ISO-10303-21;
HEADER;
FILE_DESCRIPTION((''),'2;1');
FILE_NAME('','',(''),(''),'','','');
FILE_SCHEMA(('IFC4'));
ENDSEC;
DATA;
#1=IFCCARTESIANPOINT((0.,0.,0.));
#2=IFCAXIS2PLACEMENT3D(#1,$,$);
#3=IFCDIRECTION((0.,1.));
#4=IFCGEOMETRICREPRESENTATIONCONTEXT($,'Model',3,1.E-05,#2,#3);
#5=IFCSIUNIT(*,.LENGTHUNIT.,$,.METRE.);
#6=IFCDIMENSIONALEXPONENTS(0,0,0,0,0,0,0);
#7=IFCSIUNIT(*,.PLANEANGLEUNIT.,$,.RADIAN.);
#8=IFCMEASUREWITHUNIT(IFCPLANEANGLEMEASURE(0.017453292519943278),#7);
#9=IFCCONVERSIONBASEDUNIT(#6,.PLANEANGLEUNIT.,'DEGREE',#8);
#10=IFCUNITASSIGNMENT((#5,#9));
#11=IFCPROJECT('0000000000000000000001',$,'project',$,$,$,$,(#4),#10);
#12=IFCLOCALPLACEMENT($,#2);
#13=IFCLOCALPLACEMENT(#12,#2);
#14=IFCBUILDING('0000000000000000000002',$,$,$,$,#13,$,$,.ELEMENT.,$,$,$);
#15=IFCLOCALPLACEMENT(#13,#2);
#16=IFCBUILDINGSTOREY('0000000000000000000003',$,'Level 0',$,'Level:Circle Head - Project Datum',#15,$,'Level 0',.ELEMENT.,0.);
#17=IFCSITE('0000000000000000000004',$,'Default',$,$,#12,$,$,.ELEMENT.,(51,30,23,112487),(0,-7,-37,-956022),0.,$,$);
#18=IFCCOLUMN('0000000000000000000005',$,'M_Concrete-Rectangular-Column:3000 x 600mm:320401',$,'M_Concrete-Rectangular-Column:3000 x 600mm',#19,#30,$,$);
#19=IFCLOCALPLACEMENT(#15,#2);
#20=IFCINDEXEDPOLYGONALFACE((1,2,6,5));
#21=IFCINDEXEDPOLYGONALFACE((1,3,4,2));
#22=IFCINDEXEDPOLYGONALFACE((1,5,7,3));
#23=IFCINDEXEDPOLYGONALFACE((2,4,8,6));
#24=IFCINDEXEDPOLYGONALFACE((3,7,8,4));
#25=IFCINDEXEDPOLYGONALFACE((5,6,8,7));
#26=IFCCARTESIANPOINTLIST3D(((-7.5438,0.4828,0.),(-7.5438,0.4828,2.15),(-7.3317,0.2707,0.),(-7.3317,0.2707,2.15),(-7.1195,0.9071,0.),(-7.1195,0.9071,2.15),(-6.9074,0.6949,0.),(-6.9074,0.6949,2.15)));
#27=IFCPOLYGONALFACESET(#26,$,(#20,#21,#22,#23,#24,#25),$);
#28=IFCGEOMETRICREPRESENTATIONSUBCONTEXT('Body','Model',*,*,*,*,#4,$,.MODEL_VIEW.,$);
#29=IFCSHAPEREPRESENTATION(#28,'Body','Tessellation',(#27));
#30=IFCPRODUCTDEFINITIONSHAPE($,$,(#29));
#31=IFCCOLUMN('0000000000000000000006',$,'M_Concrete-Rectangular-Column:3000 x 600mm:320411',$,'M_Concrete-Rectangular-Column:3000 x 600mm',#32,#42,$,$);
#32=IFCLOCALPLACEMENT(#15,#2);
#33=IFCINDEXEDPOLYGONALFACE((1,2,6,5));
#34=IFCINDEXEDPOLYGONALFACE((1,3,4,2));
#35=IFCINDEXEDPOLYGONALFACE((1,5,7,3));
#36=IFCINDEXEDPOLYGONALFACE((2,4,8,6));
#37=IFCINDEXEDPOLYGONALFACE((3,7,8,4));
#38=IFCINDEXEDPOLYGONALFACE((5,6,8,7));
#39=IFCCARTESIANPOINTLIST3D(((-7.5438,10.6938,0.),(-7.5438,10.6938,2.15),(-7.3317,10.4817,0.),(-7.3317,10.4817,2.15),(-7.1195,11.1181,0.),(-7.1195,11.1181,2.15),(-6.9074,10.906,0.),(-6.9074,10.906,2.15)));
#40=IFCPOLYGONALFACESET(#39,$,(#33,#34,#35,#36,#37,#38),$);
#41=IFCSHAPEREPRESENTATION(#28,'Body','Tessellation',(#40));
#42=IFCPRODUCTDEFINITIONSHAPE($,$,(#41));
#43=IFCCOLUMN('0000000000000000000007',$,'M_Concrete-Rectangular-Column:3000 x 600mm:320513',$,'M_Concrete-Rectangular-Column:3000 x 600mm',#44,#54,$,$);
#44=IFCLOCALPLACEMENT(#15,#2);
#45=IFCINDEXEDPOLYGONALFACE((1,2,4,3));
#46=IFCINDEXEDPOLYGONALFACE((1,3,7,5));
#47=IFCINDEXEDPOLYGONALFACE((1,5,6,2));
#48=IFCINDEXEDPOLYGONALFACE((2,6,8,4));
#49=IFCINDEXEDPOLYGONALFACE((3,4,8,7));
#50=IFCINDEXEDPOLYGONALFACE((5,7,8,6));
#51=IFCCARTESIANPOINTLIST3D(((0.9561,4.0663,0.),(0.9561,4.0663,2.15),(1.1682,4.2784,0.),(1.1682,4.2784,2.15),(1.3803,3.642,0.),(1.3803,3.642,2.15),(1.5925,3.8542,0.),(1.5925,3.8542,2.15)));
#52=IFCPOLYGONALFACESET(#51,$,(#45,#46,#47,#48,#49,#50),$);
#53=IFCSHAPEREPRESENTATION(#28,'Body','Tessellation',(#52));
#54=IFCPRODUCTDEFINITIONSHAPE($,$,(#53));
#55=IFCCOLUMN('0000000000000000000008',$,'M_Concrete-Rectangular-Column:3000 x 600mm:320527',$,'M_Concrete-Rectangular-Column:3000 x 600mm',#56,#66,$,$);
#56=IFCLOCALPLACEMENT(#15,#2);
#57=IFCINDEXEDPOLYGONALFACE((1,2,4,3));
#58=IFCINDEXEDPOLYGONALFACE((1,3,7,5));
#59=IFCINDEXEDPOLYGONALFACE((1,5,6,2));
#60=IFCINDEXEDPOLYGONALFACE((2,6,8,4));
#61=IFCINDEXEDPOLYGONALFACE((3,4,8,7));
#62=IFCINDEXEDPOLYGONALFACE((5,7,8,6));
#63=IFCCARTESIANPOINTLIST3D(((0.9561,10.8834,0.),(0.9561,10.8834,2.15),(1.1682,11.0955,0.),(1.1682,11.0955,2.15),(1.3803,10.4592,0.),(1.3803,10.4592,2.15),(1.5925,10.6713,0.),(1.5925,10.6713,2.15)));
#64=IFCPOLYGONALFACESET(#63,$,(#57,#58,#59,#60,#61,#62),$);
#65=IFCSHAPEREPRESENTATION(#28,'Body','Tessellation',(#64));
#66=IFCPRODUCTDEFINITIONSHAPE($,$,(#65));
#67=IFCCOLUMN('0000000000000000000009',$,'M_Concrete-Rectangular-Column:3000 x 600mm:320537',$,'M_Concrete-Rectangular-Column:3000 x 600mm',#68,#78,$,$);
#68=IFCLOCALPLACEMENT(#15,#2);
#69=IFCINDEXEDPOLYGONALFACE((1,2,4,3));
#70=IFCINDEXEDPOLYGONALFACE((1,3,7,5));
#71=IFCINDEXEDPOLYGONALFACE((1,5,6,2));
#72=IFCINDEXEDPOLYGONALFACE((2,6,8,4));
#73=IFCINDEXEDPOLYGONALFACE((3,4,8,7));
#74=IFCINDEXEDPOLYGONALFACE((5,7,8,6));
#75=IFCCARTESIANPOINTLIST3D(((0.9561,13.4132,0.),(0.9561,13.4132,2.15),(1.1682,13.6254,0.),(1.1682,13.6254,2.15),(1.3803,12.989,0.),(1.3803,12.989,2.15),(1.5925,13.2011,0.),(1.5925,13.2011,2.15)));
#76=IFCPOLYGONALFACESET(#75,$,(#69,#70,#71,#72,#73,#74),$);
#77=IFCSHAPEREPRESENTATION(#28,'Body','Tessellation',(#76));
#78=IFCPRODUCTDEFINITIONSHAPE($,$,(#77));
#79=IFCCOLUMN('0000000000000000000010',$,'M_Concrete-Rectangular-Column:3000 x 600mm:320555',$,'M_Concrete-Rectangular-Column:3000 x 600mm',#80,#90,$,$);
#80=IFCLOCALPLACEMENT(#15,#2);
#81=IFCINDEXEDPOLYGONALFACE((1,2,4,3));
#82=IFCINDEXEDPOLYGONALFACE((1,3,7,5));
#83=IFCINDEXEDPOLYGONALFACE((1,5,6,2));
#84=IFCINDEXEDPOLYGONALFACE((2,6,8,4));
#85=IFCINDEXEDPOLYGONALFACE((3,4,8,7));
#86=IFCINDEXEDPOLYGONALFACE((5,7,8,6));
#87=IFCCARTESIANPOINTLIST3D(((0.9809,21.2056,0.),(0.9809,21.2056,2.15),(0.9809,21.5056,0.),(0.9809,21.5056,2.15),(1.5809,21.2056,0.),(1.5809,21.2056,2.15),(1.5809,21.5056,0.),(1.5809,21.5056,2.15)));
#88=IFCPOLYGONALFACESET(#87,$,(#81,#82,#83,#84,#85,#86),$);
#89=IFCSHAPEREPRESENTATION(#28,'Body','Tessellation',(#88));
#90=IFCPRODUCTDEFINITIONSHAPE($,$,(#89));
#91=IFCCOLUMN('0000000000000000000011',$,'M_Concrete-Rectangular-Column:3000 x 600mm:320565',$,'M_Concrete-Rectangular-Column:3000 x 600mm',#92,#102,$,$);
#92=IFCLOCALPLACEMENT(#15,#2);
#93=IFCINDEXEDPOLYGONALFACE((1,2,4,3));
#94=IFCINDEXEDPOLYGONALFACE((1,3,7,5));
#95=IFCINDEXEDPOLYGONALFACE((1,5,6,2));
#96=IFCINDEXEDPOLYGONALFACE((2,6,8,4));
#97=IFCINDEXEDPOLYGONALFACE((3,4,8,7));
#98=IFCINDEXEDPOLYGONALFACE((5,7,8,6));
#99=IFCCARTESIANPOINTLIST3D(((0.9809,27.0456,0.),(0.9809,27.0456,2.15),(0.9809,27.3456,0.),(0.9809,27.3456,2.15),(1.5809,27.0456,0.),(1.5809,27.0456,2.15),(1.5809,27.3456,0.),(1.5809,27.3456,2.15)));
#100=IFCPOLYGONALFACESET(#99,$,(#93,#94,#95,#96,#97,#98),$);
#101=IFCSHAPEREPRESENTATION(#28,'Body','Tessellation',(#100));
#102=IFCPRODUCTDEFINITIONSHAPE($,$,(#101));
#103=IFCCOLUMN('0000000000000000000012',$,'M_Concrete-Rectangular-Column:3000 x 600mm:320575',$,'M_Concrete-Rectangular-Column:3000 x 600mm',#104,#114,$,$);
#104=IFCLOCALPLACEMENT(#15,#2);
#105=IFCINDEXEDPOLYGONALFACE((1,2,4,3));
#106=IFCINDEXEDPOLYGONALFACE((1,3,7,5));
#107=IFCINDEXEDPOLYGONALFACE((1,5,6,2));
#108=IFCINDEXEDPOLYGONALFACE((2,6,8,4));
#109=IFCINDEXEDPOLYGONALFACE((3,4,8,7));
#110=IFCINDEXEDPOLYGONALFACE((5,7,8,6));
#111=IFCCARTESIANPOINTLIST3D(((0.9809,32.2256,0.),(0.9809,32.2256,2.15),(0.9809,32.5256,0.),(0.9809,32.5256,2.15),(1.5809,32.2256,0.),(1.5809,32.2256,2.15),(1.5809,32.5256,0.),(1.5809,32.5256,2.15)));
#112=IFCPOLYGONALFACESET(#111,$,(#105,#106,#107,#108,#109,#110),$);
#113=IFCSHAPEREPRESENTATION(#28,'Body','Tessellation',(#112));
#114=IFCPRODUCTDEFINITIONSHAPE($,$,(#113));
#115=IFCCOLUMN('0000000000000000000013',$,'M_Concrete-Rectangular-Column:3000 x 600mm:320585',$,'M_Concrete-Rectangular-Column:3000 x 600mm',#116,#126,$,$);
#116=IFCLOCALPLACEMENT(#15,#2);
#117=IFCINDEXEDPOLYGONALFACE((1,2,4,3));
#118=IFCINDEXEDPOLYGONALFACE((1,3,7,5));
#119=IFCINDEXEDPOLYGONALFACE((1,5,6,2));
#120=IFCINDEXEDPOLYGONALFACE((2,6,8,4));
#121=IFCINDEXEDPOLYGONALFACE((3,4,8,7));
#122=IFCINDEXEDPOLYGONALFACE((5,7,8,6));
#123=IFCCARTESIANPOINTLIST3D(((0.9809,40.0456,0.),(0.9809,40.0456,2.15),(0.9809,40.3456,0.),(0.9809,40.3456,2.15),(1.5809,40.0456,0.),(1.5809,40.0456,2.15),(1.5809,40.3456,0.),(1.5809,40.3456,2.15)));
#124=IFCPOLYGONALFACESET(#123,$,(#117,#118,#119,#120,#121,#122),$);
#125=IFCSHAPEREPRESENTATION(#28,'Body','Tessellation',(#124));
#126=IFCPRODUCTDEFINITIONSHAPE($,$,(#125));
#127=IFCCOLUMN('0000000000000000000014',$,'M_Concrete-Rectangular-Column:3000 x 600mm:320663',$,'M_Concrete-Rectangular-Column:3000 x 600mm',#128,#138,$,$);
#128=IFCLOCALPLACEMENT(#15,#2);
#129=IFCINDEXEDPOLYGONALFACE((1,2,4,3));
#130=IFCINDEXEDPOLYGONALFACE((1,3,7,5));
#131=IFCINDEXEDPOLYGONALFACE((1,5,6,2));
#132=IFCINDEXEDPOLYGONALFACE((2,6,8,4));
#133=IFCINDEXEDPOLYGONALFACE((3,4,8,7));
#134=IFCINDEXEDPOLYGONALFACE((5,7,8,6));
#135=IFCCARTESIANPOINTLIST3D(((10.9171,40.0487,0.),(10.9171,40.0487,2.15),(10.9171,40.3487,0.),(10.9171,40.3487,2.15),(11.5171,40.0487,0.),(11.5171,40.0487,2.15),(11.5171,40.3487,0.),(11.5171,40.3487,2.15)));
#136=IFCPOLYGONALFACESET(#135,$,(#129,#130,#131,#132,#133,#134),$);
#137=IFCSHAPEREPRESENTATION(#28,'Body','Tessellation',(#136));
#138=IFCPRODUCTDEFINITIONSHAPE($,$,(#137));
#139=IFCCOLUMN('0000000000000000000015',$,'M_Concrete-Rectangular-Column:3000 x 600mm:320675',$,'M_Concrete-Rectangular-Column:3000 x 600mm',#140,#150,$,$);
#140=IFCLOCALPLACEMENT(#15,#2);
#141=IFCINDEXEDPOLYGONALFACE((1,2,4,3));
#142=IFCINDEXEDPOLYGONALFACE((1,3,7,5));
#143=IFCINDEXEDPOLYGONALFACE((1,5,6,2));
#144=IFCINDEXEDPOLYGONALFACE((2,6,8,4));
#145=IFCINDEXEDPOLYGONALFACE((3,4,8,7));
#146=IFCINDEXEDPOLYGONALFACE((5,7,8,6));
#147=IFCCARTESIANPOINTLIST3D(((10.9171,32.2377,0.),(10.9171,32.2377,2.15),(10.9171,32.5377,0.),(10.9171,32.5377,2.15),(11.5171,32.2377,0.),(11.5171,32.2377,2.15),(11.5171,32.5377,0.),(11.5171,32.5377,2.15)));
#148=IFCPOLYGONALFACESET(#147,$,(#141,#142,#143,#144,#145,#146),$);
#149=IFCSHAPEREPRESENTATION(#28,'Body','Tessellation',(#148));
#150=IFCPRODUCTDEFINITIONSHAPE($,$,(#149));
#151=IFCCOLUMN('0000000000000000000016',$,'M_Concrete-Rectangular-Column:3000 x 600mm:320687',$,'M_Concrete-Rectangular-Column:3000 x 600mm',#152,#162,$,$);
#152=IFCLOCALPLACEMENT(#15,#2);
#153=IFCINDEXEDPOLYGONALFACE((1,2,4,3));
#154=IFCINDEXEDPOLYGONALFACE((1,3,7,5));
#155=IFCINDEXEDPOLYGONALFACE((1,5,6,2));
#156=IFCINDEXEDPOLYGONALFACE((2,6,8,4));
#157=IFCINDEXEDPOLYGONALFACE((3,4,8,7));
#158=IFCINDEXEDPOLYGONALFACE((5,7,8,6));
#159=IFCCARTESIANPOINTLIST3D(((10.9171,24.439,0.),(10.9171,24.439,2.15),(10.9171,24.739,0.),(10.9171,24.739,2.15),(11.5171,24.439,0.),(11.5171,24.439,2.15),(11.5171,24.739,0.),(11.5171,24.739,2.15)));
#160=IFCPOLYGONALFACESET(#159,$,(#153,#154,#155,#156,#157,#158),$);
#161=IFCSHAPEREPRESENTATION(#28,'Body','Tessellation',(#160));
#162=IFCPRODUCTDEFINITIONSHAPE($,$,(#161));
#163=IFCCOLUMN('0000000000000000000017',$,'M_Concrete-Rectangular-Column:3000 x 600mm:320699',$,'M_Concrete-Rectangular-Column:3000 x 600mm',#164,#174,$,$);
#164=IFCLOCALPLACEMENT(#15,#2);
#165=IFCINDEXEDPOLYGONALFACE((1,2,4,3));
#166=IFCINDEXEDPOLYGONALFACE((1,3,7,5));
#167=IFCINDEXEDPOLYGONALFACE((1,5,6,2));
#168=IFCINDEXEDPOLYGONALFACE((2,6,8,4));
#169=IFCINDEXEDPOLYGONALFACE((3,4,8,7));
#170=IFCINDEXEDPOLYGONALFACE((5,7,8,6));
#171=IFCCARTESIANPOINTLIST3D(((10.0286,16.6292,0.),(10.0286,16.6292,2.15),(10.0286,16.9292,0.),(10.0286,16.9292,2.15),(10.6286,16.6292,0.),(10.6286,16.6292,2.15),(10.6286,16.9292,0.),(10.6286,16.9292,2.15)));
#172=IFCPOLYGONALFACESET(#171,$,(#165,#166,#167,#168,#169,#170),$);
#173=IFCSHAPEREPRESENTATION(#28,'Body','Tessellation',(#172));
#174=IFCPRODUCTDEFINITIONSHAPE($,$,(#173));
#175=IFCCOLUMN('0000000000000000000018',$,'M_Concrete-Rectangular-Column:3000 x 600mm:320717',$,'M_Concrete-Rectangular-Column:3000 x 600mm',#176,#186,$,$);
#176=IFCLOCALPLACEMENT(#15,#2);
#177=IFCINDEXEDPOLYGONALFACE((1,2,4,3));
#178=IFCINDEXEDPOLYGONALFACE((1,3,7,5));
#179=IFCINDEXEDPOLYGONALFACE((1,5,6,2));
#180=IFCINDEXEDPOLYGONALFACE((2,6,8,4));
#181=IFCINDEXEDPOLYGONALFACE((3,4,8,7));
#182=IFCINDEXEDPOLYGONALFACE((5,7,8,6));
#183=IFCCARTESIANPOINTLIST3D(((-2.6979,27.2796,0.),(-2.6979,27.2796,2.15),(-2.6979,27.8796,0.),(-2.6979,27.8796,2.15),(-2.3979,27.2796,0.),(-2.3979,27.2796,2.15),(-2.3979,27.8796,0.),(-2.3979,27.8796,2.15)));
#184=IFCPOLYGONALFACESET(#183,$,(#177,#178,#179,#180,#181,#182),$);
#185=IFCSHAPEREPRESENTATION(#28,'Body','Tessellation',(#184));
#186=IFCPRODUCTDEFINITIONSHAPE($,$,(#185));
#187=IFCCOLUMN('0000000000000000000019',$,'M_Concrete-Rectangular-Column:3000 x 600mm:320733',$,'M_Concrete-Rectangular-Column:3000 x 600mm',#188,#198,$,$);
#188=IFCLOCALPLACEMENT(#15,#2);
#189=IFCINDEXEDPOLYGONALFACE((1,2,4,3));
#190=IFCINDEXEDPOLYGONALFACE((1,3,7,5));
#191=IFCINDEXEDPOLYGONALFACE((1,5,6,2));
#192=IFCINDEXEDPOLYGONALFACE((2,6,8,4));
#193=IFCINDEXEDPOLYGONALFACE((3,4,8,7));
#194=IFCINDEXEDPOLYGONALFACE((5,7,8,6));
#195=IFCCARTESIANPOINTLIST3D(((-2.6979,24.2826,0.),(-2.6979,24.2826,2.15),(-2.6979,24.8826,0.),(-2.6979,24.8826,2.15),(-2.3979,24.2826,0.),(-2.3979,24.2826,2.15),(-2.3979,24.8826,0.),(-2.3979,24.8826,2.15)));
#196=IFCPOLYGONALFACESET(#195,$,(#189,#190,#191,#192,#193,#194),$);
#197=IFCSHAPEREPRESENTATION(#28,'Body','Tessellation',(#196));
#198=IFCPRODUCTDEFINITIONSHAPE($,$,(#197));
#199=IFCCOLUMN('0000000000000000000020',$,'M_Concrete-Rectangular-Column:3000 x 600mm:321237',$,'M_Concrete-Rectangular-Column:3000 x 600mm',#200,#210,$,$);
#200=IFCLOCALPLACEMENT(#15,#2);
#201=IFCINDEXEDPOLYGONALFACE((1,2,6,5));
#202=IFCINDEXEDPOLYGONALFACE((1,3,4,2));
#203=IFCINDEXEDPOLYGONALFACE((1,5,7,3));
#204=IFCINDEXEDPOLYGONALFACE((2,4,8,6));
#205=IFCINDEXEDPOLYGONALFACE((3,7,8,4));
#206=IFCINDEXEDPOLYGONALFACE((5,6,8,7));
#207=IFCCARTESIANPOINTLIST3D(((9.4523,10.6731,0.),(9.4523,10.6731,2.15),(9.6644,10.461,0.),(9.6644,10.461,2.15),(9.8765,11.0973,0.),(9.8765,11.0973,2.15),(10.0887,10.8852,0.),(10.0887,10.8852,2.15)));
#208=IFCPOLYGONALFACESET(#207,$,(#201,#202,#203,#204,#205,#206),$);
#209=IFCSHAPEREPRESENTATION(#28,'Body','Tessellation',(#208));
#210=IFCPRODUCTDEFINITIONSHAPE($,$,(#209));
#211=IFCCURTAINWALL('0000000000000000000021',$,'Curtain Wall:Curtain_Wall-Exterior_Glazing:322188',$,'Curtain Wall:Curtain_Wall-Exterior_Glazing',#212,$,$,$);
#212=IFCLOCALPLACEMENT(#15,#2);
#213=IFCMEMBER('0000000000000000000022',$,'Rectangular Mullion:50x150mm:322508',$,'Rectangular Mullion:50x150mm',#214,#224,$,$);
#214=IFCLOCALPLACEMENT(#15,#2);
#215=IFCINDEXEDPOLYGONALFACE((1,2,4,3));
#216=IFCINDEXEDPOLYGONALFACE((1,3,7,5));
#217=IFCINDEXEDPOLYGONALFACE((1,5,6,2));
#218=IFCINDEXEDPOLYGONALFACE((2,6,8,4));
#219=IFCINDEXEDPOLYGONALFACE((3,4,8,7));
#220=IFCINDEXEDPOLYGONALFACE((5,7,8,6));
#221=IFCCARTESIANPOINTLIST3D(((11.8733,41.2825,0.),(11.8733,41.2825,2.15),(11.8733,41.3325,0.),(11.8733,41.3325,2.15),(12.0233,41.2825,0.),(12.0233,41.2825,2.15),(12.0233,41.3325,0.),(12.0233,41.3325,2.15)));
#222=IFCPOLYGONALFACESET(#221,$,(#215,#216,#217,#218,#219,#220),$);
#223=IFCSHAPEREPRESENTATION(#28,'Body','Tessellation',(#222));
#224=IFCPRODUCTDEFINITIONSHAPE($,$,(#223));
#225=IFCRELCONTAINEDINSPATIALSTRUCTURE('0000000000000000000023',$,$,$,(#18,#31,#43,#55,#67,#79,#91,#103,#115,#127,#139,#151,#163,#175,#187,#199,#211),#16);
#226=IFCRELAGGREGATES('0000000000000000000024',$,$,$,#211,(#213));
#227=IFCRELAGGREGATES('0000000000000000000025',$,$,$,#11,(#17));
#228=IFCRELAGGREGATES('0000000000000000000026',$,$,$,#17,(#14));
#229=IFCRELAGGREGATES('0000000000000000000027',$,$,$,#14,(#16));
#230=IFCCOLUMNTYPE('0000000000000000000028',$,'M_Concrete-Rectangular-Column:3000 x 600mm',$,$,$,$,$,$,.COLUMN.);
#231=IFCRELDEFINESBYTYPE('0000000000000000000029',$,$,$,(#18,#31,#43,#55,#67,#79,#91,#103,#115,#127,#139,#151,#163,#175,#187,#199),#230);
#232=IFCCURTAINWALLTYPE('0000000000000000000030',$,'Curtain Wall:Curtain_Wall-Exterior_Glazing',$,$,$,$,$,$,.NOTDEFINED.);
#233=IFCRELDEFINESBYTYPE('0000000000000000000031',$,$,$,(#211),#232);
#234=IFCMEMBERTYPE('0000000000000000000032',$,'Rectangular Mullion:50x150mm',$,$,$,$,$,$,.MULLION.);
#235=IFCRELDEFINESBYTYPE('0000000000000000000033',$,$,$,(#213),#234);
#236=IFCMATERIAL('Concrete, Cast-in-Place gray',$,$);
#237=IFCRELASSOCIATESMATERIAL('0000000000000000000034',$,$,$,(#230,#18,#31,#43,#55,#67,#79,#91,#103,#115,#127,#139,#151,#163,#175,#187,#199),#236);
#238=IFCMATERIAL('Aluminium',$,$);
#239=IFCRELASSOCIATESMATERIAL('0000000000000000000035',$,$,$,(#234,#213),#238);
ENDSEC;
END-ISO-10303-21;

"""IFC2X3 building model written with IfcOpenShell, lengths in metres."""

from ifc_helpers import new_model, entity, si_unit, converted_unit, direction, frame, origin, origin_2d_with_axis, place, context, subcontext, project, spatial, rectangle, extrude, source, transform, mapped, material, type_object, type_shapes, element, aggregate, save


model = new_model("IFC2X3")

# Units and contexts
model_context = context("Model", 3, precision=1e-05, world=origin(), true_north=direction((0.0, 1.0)))
body_context = subcontext(model_context, "Body", "Model", "MODEL_VIEW")
ifc_project = project(units=[si_unit("LENGTHUNIT", "METRE"), converted_unit("PLANEANGLEUNIT", "DEGREE", entity("IfcPlaneAngleMeasure", 0.017453292519943278), si_unit("PLANEANGLEUNIT", "RADIAN"), dimensions=[0, 0, 0, 0, 0, 0, 0])], contexts=[model_context])

# Site, building, storey
site_placement = place(None, origin())
site = spatial("IfcSite", under=ifc_project, at=site_placement, Name="Default", CompositionType="ELEMENT", RefLatitude=(51, 30, 23, 112487), RefLongitude=(0, -7, -37, -956022), RefElevation=0.0)
building_placement = place(site_placement, origin())
building = spatial("IfcBuilding", under=site, at=building_placement, CompositionType="ELEMENT")
storey_placement = place(building_placement, origin())
storey = spatial("IfcBuildingStorey", under=building, at=storey_placement, Name="Level 0", ObjectType="Level:Circle Head - Project Datum", LongName="Level 0", CompositionType="ELEMENT", Elevation=0.0)

# Columns
ifc_material_1 = material(Name="Concrete, Cast-in-Place gray")
column_type_1 = type_object("IfcColumnType", Name="M_Concrete-Rectangular-Column:3000 x 600mm", PredefinedType="COLUMN", material=ifc_material_1)
shared_shape_1 = source(origin(), body_context, "Body", "SweptSolid", [
    extrude(rectangle(XDim=0.3, YDim=0.6, at=origin_2d_with_axis()), frame((0.0, 0.0, 0.0), z_axis=(0.0, 0.0, 1.0), x_axis=(-1.0, 0.0, 0.0)), (0.0, 0.0, 1.0), 2.15),
])
type_shapes(column_type_1, [shared_shape_1])
for number, where, z_axis, x_axis, name in (
    (1, (-7.2256, 0.5889, 0.0), (0.0, 0.0, 1.0), (0.707107, -0.707107, 0.0), "M_Concrete-Rectangular-Column:3000 x 600mm:320401"),
    (2, (-7.2256, 10.7999, 0.0), (0.0, 0.0, 1.0), (0.707107, -0.707107, 0.0), "M_Concrete-Rectangular-Column:3000 x 600mm:320411"),
    (3, (1.2743, 3.9602, 0.0), (0.0, 0.0, 1.0), (0.707107, 0.707107, 0.0), "M_Concrete-Rectangular-Column:3000 x 600mm:320513"),
    (4, (1.2743, 10.7773, 0.0), (0.0, 0.0, 1.0), (0.707107, 0.707107, 0.0), "M_Concrete-Rectangular-Column:3000 x 600mm:320527"),
    (5, (1.2743, 13.3072, 0.0), (0.0, 0.0, 1.0), (0.707107, 0.707107, 0.0), "M_Concrete-Rectangular-Column:3000 x 600mm:320537"),
    (6, (1.2809, 21.3556, 0.0), (0.0, 0.0, 1.0), (0.0, -1.0, 0.0), "M_Concrete-Rectangular-Column:3000 x 600mm:320555"),
    (7, (1.2809, 27.1956, 0.0), (0.0, 0.0, 1.0), (0.0, -1.0, 0.0), "M_Concrete-Rectangular-Column:3000 x 600mm:320565"),
    (8, (1.2809, 32.3756, 0.0), (0.0, 0.0, 1.0), (0.0, -1.0, 0.0), "M_Concrete-Rectangular-Column:3000 x 600mm:320575"),
    (9, (1.2809, 40.1956, 0.0), (0.0, 0.0, 1.0), (0.0, -1.0, 0.0), "M_Concrete-Rectangular-Column:3000 x 600mm:320585"),
    (10, (11.2171, 40.1987, 0.0), (0.0, 0.0, 1.0), (0.0, -1.0, 0.0), "M_Concrete-Rectangular-Column:3000 x 600mm:320663"),
    (11, (11.2171, 32.3877, 0.0), (0.0, 0.0, 1.0), (0.0, -1.0, 0.0), "M_Concrete-Rectangular-Column:3000 x 600mm:320675"),
    (12, (11.2171, 24.589, 0.0), (0.0, 0.0, 1.0), (0.0, -1.0, 0.0), "M_Concrete-Rectangular-Column:3000 x 600mm:320687"),
    (13, (10.3286, 16.7792, 0.0), (0.0, 0.0, 1.0), (0.0, -1.0, 0.0), "M_Concrete-Rectangular-Column:3000 x 600mm:320699"),
):
    element("IfcColumn", number, at=place(storey_placement, frame(where, z_axis=z_axis, x_axis=x_axis)), inside=storey, type_object=column_type_1, material=ifc_material_1, Name=name, ObjectType="M_Concrete-Rectangular-Column:3000 x 600mm", context=body_context, shape_type="MappedRepresentation", body=[
        mapped(shared_shape_1, transform((0.0, 0.0, 0.0), scale=1.0)),
    ])
for number, where, name in (
    (14, (-2.5479, 27.5796, 0.0), "M_Concrete-Rectangular-Column:3000 x 600mm:320717"),
    (15, (-2.5479, 24.5826, 0.0), "M_Concrete-Rectangular-Column:3000 x 600mm:320733"),
):
    element("IfcColumn", number, at=place(storey_placement, frame(where)), inside=storey, type_object=column_type_1, material=ifc_material_1, Name=name, ObjectType="M_Concrete-Rectangular-Column:3000 x 600mm", context=body_context, shape_type="MappedRepresentation", body=[
        mapped(shared_shape_1, transform((0.0, 0.0, 0.0), scale=1.0)),
    ])
column_1_placement = place(storey_placement, frame((9.7705, 10.7791, 0.0), z_axis=(0.0, 0.0, 1.0), x_axis=(0.707107, -0.707107, 0.0)))
element("IfcColumn", 16, at=column_1_placement, inside=storey, type_object=column_type_1, material=ifc_material_1, Name="M_Concrete-Rectangular-Column:3000 x 600mm:321237", ObjectType="M_Concrete-Rectangular-Column:3000 x 600mm", context=body_context, shape_type="MappedRepresentation", body=[
    mapped(shared_shape_1, transform((0.0, 0.0, 0.0), scale=1.0)),
])

# Curtain wall, member
curtain_wall_type = type_object("IfcCurtainWallType", Name="Curtain Wall:Curtain_Wall-Exterior_Glazing", PredefinedType="NOTDEFINED")
curtain_wall_placement = place(storey_placement, origin())
curtain_wall = element("IfcCurtainWall", 17, at=curtain_wall_placement, inside=storey, type_object=curtain_wall_type, Name="Curtain Wall:Curtain_Wall-Exterior_Glazing:322188", ObjectType="Curtain Wall:Curtain_Wall-Exterior_Glazing")
ifc_material_2 = material(Name="Aluminium")
member_type_1 = type_object("IfcMemberType", Name="Rectangular Mullion:50x150mm", PredefinedType="MULLION", material=ifc_material_2)
shared_shape_2 = source(origin(), body_context, "Body", "SweptSolid", [
    extrude(rectangle(XDim=0.05, YDim=0.15, at=origin_2d_with_axis()), frame((0.0, 0.0, -2.15), z_axis=(0.0, 0.0, 1.0), x_axis=(-1.0, 0.0, 0.0)), (0.0, 0.0, 1.0), 2.15),
])
type_shapes(member_type_1, [shared_shape_2])
member_1_placement = place(curtain_wall_placement, frame((11.9483, 41.3075, 0.0), z_axis=(0.0, 0.0, -1.0), x_axis=(0.0, -1.0, 0.0)))
member_1 = element("IfcMember", 18, at=member_1_placement, type_object=member_type_1, material=ifc_material_2, Name="Rectangular Mullion:50x150mm:322508", ObjectType="Rectangular Mullion:50x150mm", context=body_context, shape_type="MappedRepresentation", body=[
    mapped(shared_shape_2, transform((0.0, 0.0, 0.0), scale=1.0)),
])
aggregate(curtain_wall, [member_1])

save(model, "model.ifc")
